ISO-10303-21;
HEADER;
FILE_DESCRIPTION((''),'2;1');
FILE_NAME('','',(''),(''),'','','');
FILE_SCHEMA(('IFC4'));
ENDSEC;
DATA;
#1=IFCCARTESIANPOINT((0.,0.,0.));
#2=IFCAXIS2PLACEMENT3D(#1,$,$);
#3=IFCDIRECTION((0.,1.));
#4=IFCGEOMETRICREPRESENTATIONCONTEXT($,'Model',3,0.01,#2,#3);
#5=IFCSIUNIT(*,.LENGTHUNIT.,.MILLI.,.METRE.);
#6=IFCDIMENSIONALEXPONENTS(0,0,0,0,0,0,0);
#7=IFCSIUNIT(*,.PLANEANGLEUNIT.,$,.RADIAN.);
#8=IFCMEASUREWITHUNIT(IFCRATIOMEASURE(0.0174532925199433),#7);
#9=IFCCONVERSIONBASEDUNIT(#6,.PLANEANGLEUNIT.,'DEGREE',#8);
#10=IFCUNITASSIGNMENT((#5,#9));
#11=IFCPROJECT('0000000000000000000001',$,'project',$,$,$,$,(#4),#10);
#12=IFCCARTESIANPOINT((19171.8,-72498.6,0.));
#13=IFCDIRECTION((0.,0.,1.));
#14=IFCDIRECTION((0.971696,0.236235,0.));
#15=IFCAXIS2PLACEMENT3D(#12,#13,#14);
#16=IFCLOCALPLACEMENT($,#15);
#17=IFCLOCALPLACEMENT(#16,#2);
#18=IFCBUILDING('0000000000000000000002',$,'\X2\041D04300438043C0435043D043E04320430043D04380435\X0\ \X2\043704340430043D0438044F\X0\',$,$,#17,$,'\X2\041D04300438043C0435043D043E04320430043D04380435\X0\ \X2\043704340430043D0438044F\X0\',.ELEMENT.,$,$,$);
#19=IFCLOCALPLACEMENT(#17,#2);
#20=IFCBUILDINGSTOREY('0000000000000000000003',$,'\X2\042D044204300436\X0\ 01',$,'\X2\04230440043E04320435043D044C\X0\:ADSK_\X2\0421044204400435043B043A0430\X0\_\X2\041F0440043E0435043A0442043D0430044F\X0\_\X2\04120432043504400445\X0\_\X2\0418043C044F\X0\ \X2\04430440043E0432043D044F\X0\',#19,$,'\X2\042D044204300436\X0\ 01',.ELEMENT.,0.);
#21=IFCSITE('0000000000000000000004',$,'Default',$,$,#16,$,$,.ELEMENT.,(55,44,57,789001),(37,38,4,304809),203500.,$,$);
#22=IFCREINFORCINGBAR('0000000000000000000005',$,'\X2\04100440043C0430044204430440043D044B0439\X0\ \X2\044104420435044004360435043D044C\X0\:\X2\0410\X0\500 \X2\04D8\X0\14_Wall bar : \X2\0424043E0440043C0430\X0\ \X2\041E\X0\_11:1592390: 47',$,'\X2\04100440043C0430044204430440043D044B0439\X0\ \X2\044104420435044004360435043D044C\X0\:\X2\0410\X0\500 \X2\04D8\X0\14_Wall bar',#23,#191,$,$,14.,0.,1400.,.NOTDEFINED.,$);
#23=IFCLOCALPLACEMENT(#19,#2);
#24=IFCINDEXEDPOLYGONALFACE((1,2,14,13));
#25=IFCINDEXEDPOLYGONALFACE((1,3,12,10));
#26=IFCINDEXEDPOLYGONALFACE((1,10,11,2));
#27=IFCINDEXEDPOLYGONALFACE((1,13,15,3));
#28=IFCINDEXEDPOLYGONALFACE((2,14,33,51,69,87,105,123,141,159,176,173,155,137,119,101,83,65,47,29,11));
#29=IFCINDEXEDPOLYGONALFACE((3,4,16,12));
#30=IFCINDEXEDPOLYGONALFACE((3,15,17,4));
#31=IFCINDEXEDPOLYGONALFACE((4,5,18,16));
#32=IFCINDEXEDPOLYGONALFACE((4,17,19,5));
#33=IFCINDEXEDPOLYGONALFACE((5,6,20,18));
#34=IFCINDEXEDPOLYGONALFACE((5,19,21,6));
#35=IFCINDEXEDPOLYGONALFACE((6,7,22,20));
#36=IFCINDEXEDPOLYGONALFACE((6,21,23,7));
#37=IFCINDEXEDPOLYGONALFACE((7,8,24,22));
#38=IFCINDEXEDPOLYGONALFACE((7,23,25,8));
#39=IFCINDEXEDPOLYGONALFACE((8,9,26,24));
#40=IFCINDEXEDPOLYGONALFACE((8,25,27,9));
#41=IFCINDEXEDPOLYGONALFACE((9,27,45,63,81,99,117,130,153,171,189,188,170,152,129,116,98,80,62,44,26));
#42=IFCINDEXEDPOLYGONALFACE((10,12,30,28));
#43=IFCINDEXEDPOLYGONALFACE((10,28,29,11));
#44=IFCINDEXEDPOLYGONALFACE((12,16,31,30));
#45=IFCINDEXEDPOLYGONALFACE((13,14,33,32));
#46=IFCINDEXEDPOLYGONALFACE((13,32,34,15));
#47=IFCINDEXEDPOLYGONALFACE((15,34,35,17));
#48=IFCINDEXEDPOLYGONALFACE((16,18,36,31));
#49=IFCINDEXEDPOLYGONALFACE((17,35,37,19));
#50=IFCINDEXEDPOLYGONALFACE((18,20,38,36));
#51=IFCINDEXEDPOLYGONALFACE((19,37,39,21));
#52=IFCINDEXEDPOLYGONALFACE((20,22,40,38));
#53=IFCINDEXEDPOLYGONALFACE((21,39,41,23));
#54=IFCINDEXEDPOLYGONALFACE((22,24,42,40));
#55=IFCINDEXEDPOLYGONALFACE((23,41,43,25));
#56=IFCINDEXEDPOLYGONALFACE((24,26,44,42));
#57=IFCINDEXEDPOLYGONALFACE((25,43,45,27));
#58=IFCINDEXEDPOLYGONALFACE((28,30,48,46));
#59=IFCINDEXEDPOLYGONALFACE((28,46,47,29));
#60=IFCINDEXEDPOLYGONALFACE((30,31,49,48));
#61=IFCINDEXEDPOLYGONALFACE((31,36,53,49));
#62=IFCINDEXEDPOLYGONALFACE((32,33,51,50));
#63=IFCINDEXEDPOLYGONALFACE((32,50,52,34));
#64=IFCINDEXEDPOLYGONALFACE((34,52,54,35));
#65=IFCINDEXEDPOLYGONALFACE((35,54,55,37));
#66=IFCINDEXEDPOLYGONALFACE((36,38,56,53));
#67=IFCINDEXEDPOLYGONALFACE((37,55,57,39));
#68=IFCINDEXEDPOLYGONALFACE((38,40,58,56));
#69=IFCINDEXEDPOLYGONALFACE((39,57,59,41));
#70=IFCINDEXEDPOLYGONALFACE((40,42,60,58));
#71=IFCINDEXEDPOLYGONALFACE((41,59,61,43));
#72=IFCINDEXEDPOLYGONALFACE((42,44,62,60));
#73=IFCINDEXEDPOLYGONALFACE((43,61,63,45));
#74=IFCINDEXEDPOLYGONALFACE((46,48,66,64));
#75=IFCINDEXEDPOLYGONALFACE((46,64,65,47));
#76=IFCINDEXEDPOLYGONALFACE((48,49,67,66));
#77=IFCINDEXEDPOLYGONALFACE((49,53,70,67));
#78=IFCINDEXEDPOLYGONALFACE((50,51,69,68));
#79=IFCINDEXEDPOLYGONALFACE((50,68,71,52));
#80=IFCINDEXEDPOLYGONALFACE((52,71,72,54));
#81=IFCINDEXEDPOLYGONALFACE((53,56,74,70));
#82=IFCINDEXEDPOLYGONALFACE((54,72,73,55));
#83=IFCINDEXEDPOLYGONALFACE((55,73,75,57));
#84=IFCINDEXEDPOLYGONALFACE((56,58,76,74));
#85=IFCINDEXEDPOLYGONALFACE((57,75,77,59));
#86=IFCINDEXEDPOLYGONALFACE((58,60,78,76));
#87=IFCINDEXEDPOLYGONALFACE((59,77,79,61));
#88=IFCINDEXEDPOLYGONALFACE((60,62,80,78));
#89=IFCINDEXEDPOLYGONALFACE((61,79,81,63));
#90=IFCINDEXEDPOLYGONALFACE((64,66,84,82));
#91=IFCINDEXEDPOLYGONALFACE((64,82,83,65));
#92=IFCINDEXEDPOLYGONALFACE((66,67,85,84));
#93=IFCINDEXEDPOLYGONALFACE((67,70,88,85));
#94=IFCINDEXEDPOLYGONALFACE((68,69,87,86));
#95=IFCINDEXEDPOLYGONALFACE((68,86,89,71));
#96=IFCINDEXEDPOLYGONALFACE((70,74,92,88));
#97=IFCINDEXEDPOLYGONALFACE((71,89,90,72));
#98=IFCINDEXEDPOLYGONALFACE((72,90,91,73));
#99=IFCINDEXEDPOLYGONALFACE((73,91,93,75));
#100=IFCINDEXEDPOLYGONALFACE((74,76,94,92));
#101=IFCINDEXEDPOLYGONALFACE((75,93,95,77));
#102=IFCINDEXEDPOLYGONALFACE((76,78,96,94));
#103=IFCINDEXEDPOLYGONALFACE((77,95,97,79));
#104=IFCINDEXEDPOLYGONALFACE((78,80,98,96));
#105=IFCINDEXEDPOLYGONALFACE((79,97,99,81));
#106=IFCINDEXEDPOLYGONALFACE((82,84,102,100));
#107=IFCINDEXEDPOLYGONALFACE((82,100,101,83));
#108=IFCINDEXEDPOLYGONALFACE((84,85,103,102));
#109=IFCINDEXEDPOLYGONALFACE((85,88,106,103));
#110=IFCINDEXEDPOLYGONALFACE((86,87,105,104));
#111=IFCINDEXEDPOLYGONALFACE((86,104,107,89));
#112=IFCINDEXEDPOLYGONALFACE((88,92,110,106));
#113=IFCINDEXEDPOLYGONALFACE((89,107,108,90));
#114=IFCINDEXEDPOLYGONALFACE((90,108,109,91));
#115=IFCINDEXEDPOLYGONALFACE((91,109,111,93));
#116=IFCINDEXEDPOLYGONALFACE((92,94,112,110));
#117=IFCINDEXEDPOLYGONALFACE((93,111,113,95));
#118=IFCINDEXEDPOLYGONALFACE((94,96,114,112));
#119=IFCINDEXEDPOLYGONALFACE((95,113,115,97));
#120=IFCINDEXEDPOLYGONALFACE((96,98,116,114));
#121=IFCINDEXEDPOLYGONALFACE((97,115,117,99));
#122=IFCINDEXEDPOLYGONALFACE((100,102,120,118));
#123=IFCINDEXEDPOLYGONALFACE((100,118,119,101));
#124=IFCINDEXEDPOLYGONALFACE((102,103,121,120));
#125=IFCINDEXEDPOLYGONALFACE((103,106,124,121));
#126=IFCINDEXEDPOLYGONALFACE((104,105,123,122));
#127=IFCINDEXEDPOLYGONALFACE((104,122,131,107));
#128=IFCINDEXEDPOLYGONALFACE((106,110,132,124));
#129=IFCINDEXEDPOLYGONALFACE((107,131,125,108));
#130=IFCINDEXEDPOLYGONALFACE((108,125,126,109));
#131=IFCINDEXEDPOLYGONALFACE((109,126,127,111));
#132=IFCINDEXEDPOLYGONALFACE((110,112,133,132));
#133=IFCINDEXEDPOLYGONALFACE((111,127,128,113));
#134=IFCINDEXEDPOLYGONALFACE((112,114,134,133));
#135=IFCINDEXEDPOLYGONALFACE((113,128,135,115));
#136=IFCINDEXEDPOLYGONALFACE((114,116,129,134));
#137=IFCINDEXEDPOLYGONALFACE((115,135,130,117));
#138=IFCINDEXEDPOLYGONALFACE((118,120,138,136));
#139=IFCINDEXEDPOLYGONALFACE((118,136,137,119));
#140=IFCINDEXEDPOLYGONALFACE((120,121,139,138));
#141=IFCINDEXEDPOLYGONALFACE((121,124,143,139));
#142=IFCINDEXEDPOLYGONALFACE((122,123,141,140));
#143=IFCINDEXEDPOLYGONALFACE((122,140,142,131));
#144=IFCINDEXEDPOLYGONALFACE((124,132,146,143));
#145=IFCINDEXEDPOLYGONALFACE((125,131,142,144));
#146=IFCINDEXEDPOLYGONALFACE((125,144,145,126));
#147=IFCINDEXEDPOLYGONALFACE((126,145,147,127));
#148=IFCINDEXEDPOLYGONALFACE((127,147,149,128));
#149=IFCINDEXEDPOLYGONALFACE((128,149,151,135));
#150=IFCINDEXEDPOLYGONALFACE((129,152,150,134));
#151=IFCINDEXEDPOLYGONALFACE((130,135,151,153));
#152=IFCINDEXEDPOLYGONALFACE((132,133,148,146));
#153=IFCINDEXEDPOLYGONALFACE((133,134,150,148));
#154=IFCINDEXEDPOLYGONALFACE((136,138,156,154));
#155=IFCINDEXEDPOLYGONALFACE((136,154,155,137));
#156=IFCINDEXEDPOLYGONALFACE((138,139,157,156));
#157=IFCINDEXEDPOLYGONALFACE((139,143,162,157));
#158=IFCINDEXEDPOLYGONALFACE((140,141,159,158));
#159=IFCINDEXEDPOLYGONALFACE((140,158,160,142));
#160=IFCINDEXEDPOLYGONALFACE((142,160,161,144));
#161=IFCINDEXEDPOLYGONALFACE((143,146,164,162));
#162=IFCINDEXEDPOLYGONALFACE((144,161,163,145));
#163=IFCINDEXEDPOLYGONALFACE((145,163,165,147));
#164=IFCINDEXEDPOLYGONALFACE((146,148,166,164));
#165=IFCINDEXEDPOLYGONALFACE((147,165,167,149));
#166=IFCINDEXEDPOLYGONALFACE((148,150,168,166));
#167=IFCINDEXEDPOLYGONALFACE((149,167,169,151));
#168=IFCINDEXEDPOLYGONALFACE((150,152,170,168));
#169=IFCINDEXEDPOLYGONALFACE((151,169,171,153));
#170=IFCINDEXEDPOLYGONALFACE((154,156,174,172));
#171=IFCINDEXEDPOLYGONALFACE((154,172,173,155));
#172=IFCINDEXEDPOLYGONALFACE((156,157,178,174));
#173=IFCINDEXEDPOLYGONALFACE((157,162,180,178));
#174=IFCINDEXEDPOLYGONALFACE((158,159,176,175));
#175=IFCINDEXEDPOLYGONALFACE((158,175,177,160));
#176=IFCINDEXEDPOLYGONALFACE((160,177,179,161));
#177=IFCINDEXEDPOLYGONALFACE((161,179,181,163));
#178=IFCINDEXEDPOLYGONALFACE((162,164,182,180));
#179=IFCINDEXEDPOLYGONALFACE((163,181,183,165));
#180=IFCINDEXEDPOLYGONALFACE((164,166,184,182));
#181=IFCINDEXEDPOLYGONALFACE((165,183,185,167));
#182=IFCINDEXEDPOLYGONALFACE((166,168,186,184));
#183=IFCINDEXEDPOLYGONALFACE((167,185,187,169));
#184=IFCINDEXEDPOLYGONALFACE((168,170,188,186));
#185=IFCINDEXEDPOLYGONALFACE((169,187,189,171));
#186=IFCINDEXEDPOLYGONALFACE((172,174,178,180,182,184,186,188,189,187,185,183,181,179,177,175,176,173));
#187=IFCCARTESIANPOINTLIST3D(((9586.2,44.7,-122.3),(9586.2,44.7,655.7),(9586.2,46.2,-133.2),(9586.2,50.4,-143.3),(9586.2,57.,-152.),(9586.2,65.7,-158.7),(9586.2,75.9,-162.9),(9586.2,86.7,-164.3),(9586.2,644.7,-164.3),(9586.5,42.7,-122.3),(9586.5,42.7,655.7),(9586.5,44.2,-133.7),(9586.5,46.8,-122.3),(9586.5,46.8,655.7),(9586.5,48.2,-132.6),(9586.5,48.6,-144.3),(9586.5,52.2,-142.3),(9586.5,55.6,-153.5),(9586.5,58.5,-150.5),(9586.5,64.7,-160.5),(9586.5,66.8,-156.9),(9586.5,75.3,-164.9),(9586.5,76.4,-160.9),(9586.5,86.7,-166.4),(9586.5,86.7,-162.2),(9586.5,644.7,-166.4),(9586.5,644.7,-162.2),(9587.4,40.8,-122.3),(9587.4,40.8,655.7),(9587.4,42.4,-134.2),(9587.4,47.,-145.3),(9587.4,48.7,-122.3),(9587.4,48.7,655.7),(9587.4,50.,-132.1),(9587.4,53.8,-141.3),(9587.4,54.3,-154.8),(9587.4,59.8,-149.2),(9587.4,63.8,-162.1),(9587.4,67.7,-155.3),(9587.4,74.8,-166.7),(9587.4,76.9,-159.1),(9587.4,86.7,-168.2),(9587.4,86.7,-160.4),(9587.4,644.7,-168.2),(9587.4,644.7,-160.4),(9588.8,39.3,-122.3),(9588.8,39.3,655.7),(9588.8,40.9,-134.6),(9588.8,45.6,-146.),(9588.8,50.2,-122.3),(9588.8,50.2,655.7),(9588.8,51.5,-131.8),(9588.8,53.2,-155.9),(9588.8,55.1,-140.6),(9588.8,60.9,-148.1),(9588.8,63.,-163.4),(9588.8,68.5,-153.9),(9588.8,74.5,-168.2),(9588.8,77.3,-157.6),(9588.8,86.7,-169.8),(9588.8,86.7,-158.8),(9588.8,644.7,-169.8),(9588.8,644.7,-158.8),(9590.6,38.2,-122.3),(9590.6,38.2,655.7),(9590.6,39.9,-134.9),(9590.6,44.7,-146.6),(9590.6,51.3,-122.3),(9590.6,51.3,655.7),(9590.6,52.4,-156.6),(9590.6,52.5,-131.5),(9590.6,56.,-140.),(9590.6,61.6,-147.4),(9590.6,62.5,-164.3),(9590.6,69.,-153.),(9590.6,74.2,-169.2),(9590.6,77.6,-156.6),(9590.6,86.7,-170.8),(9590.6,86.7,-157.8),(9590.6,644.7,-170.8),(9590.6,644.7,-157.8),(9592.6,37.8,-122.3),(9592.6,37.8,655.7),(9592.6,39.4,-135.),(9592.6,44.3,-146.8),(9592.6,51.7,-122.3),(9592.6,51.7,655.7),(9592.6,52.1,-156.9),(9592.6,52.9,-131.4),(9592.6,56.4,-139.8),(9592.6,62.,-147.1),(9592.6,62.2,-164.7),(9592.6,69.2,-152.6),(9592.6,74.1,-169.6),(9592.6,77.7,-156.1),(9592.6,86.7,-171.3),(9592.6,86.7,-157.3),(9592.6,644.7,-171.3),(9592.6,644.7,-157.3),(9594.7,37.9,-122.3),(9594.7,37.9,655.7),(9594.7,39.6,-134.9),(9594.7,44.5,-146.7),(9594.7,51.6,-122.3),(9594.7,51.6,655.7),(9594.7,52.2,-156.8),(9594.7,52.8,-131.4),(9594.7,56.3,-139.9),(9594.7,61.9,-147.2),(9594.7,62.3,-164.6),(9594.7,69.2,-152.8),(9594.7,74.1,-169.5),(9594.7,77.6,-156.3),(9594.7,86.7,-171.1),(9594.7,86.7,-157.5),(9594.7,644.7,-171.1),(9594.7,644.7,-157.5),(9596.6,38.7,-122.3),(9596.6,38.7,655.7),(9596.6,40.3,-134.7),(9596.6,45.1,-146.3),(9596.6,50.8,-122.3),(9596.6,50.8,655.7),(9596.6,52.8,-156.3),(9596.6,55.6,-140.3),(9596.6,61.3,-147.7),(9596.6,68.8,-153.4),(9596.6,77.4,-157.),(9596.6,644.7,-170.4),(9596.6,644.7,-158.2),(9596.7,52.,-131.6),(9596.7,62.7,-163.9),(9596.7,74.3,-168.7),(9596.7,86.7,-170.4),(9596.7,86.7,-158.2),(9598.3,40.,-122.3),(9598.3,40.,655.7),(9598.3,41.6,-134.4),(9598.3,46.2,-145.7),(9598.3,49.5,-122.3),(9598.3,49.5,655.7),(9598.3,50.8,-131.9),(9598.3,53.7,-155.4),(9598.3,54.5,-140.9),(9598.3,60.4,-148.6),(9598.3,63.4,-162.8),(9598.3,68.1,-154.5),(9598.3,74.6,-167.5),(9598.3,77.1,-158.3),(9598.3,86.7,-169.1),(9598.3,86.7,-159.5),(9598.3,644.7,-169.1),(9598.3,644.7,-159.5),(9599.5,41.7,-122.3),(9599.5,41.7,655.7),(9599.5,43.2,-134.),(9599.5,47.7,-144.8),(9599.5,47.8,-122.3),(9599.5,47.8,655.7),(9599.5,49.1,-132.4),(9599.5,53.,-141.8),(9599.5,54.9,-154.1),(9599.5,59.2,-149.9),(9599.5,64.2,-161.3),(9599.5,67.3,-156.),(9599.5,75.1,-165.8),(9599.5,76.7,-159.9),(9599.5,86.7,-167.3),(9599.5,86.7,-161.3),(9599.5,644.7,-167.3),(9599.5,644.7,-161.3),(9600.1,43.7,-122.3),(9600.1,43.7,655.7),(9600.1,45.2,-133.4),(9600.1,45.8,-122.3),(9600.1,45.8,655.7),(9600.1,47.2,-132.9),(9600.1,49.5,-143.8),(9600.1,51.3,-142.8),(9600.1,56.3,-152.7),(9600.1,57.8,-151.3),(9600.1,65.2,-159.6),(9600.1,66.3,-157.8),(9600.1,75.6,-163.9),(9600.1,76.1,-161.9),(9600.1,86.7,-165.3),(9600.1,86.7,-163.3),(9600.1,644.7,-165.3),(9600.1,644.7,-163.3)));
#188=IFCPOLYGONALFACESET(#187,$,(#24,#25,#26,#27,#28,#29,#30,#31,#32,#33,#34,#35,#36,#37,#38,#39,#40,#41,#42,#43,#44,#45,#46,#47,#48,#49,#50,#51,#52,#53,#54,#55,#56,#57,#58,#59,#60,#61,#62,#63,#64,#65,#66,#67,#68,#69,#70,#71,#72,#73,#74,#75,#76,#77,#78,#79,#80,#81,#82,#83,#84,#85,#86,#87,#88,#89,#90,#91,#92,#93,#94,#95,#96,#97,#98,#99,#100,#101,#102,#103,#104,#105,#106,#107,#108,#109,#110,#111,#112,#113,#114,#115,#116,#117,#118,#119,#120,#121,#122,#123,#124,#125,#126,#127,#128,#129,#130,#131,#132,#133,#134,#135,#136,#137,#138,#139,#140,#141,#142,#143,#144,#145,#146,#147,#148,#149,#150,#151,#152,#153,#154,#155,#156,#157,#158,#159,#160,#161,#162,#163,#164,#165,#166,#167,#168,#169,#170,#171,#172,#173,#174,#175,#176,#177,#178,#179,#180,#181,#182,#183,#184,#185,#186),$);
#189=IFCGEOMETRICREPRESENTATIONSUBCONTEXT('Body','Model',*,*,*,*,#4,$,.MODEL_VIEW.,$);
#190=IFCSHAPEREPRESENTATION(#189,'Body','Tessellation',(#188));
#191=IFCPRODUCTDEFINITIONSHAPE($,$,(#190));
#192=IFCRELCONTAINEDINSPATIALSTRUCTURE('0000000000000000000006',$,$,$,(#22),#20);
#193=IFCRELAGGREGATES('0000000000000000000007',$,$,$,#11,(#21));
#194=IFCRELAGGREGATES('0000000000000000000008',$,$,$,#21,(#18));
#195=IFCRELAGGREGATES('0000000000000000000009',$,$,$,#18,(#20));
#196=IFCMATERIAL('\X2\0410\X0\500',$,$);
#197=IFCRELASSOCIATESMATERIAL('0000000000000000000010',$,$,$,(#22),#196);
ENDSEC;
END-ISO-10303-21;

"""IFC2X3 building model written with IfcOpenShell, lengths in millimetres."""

from ifc_helpers import new_model, entity, si_unit, converted_unit, direction, frame, origin, place, context, subcontext, project, spatial, material, element, save


model = new_model("IFC2X3")

# Units and contexts
model_context = context("Model", 3, precision=0.01, world=origin(), true_north=direction((0.0, 1.0)))
body_context = subcontext(model_context, "Body", "Model", "MODEL_VIEW")
ifc_project = project(units=[si_unit("LENGTHUNIT", "METRE", prefix="MILLI"), converted_unit("PLANEANGLEUNIT", "DEGREE", entity("IfcRatioMeasure", 0.0174532925199433), si_unit("PLANEANGLEUNIT", "RADIAN"), dimensions=[0, 0, 0, 0, 0, 0, 0])], contexts=[model_context])

# Site, building, storey
site_placement = place(None, frame((19171.8, -72498.6, 0.0), z_axis=(0.0, 0.0, 1.0), x_axis=(0.971696, 0.236235, 0.0)))
site = spatial("IfcSite", under=ifc_project, at=site_placement, Name="Default", CompositionType="ELEMENT", RefLatitude=(55, 44, 57, 789001), RefLongitude=(37, 38, 4, 304809), RefElevation=203500.0)
building_placement = place(site_placement, origin())
building = spatial("IfcBuilding", under=site, at=building_placement, Name="Наименование здания", LongName="Наименование здания", CompositionType="ELEMENT")
storey_placement = place(building_placement, origin())
storey = spatial("IfcBuildingStorey", under=building, at=storey_placement, Name="Этаж 01", ObjectType="Уровень:ADSK_Стрелка_Проектная_Вверх_Имя уровня", LongName="Этаж 01", CompositionType="ELEMENT", Elevation=0.0)

# Reinforcing bar
ifc_material = material(Name="А500")
placement = place(storey_placement, origin())
element("IfcReinforcingBar", 1, at=placement, inside=storey, material=ifc_material, Name="Арматурный стержень:А500 Ә14_Wall bar : Форма О_11:1592390: 47", ObjectType="Арматурный стержень:А500 Ә14_Wall bar", BarLength=1400.0, BarRole="NOTDEFINED", CrossSectionArea=0.0, NominalDiameter=14.0, context=body_context, shape_type="AdvancedSweptSolid", body=[
    entity("IfcSweptDiskSolid", entity("IfcCompositeCurve", [entity("IfcCompositeCurveSegment", "CONTINUOUS", True, entity("IfcPolyline", [entity("IfcCartesianPoint", [9593.1, 44.7, 655.7]), entity("IfcCartesianPoint", [9593.1, 44.7, -122.3])])), entity("IfcCompositeCurveSegment", "CONTINUOUS", True, entity("IfcTrimmedCurve", entity("IfcCircle", entity("IfcAxis2Placement3D", entity("IfcCartesianPoint", [9593.1, 86.7, -122.3]), entity("IfcDirection", [1.0, 0.0, 0.0]), entity("IfcDirection", [0.0, 0.0, -1.0])), 42.0), [entity("IfcParameterValue", 270.0)], [entity("IfcParameterValue", 360.0)], True, "PARAMETER")), entity("IfcCompositeCurveSegment", "CONTINUOUS", True, entity("IfcPolyline", [entity("IfcCartesianPoint", [9593.1, 86.7, -164.3]), entity("IfcCartesianPoint", [9593.1, 644.7, -164.3])]))], False), 7.0, None, 0.0, 92.0),
])

save(model, "model.ifc")
